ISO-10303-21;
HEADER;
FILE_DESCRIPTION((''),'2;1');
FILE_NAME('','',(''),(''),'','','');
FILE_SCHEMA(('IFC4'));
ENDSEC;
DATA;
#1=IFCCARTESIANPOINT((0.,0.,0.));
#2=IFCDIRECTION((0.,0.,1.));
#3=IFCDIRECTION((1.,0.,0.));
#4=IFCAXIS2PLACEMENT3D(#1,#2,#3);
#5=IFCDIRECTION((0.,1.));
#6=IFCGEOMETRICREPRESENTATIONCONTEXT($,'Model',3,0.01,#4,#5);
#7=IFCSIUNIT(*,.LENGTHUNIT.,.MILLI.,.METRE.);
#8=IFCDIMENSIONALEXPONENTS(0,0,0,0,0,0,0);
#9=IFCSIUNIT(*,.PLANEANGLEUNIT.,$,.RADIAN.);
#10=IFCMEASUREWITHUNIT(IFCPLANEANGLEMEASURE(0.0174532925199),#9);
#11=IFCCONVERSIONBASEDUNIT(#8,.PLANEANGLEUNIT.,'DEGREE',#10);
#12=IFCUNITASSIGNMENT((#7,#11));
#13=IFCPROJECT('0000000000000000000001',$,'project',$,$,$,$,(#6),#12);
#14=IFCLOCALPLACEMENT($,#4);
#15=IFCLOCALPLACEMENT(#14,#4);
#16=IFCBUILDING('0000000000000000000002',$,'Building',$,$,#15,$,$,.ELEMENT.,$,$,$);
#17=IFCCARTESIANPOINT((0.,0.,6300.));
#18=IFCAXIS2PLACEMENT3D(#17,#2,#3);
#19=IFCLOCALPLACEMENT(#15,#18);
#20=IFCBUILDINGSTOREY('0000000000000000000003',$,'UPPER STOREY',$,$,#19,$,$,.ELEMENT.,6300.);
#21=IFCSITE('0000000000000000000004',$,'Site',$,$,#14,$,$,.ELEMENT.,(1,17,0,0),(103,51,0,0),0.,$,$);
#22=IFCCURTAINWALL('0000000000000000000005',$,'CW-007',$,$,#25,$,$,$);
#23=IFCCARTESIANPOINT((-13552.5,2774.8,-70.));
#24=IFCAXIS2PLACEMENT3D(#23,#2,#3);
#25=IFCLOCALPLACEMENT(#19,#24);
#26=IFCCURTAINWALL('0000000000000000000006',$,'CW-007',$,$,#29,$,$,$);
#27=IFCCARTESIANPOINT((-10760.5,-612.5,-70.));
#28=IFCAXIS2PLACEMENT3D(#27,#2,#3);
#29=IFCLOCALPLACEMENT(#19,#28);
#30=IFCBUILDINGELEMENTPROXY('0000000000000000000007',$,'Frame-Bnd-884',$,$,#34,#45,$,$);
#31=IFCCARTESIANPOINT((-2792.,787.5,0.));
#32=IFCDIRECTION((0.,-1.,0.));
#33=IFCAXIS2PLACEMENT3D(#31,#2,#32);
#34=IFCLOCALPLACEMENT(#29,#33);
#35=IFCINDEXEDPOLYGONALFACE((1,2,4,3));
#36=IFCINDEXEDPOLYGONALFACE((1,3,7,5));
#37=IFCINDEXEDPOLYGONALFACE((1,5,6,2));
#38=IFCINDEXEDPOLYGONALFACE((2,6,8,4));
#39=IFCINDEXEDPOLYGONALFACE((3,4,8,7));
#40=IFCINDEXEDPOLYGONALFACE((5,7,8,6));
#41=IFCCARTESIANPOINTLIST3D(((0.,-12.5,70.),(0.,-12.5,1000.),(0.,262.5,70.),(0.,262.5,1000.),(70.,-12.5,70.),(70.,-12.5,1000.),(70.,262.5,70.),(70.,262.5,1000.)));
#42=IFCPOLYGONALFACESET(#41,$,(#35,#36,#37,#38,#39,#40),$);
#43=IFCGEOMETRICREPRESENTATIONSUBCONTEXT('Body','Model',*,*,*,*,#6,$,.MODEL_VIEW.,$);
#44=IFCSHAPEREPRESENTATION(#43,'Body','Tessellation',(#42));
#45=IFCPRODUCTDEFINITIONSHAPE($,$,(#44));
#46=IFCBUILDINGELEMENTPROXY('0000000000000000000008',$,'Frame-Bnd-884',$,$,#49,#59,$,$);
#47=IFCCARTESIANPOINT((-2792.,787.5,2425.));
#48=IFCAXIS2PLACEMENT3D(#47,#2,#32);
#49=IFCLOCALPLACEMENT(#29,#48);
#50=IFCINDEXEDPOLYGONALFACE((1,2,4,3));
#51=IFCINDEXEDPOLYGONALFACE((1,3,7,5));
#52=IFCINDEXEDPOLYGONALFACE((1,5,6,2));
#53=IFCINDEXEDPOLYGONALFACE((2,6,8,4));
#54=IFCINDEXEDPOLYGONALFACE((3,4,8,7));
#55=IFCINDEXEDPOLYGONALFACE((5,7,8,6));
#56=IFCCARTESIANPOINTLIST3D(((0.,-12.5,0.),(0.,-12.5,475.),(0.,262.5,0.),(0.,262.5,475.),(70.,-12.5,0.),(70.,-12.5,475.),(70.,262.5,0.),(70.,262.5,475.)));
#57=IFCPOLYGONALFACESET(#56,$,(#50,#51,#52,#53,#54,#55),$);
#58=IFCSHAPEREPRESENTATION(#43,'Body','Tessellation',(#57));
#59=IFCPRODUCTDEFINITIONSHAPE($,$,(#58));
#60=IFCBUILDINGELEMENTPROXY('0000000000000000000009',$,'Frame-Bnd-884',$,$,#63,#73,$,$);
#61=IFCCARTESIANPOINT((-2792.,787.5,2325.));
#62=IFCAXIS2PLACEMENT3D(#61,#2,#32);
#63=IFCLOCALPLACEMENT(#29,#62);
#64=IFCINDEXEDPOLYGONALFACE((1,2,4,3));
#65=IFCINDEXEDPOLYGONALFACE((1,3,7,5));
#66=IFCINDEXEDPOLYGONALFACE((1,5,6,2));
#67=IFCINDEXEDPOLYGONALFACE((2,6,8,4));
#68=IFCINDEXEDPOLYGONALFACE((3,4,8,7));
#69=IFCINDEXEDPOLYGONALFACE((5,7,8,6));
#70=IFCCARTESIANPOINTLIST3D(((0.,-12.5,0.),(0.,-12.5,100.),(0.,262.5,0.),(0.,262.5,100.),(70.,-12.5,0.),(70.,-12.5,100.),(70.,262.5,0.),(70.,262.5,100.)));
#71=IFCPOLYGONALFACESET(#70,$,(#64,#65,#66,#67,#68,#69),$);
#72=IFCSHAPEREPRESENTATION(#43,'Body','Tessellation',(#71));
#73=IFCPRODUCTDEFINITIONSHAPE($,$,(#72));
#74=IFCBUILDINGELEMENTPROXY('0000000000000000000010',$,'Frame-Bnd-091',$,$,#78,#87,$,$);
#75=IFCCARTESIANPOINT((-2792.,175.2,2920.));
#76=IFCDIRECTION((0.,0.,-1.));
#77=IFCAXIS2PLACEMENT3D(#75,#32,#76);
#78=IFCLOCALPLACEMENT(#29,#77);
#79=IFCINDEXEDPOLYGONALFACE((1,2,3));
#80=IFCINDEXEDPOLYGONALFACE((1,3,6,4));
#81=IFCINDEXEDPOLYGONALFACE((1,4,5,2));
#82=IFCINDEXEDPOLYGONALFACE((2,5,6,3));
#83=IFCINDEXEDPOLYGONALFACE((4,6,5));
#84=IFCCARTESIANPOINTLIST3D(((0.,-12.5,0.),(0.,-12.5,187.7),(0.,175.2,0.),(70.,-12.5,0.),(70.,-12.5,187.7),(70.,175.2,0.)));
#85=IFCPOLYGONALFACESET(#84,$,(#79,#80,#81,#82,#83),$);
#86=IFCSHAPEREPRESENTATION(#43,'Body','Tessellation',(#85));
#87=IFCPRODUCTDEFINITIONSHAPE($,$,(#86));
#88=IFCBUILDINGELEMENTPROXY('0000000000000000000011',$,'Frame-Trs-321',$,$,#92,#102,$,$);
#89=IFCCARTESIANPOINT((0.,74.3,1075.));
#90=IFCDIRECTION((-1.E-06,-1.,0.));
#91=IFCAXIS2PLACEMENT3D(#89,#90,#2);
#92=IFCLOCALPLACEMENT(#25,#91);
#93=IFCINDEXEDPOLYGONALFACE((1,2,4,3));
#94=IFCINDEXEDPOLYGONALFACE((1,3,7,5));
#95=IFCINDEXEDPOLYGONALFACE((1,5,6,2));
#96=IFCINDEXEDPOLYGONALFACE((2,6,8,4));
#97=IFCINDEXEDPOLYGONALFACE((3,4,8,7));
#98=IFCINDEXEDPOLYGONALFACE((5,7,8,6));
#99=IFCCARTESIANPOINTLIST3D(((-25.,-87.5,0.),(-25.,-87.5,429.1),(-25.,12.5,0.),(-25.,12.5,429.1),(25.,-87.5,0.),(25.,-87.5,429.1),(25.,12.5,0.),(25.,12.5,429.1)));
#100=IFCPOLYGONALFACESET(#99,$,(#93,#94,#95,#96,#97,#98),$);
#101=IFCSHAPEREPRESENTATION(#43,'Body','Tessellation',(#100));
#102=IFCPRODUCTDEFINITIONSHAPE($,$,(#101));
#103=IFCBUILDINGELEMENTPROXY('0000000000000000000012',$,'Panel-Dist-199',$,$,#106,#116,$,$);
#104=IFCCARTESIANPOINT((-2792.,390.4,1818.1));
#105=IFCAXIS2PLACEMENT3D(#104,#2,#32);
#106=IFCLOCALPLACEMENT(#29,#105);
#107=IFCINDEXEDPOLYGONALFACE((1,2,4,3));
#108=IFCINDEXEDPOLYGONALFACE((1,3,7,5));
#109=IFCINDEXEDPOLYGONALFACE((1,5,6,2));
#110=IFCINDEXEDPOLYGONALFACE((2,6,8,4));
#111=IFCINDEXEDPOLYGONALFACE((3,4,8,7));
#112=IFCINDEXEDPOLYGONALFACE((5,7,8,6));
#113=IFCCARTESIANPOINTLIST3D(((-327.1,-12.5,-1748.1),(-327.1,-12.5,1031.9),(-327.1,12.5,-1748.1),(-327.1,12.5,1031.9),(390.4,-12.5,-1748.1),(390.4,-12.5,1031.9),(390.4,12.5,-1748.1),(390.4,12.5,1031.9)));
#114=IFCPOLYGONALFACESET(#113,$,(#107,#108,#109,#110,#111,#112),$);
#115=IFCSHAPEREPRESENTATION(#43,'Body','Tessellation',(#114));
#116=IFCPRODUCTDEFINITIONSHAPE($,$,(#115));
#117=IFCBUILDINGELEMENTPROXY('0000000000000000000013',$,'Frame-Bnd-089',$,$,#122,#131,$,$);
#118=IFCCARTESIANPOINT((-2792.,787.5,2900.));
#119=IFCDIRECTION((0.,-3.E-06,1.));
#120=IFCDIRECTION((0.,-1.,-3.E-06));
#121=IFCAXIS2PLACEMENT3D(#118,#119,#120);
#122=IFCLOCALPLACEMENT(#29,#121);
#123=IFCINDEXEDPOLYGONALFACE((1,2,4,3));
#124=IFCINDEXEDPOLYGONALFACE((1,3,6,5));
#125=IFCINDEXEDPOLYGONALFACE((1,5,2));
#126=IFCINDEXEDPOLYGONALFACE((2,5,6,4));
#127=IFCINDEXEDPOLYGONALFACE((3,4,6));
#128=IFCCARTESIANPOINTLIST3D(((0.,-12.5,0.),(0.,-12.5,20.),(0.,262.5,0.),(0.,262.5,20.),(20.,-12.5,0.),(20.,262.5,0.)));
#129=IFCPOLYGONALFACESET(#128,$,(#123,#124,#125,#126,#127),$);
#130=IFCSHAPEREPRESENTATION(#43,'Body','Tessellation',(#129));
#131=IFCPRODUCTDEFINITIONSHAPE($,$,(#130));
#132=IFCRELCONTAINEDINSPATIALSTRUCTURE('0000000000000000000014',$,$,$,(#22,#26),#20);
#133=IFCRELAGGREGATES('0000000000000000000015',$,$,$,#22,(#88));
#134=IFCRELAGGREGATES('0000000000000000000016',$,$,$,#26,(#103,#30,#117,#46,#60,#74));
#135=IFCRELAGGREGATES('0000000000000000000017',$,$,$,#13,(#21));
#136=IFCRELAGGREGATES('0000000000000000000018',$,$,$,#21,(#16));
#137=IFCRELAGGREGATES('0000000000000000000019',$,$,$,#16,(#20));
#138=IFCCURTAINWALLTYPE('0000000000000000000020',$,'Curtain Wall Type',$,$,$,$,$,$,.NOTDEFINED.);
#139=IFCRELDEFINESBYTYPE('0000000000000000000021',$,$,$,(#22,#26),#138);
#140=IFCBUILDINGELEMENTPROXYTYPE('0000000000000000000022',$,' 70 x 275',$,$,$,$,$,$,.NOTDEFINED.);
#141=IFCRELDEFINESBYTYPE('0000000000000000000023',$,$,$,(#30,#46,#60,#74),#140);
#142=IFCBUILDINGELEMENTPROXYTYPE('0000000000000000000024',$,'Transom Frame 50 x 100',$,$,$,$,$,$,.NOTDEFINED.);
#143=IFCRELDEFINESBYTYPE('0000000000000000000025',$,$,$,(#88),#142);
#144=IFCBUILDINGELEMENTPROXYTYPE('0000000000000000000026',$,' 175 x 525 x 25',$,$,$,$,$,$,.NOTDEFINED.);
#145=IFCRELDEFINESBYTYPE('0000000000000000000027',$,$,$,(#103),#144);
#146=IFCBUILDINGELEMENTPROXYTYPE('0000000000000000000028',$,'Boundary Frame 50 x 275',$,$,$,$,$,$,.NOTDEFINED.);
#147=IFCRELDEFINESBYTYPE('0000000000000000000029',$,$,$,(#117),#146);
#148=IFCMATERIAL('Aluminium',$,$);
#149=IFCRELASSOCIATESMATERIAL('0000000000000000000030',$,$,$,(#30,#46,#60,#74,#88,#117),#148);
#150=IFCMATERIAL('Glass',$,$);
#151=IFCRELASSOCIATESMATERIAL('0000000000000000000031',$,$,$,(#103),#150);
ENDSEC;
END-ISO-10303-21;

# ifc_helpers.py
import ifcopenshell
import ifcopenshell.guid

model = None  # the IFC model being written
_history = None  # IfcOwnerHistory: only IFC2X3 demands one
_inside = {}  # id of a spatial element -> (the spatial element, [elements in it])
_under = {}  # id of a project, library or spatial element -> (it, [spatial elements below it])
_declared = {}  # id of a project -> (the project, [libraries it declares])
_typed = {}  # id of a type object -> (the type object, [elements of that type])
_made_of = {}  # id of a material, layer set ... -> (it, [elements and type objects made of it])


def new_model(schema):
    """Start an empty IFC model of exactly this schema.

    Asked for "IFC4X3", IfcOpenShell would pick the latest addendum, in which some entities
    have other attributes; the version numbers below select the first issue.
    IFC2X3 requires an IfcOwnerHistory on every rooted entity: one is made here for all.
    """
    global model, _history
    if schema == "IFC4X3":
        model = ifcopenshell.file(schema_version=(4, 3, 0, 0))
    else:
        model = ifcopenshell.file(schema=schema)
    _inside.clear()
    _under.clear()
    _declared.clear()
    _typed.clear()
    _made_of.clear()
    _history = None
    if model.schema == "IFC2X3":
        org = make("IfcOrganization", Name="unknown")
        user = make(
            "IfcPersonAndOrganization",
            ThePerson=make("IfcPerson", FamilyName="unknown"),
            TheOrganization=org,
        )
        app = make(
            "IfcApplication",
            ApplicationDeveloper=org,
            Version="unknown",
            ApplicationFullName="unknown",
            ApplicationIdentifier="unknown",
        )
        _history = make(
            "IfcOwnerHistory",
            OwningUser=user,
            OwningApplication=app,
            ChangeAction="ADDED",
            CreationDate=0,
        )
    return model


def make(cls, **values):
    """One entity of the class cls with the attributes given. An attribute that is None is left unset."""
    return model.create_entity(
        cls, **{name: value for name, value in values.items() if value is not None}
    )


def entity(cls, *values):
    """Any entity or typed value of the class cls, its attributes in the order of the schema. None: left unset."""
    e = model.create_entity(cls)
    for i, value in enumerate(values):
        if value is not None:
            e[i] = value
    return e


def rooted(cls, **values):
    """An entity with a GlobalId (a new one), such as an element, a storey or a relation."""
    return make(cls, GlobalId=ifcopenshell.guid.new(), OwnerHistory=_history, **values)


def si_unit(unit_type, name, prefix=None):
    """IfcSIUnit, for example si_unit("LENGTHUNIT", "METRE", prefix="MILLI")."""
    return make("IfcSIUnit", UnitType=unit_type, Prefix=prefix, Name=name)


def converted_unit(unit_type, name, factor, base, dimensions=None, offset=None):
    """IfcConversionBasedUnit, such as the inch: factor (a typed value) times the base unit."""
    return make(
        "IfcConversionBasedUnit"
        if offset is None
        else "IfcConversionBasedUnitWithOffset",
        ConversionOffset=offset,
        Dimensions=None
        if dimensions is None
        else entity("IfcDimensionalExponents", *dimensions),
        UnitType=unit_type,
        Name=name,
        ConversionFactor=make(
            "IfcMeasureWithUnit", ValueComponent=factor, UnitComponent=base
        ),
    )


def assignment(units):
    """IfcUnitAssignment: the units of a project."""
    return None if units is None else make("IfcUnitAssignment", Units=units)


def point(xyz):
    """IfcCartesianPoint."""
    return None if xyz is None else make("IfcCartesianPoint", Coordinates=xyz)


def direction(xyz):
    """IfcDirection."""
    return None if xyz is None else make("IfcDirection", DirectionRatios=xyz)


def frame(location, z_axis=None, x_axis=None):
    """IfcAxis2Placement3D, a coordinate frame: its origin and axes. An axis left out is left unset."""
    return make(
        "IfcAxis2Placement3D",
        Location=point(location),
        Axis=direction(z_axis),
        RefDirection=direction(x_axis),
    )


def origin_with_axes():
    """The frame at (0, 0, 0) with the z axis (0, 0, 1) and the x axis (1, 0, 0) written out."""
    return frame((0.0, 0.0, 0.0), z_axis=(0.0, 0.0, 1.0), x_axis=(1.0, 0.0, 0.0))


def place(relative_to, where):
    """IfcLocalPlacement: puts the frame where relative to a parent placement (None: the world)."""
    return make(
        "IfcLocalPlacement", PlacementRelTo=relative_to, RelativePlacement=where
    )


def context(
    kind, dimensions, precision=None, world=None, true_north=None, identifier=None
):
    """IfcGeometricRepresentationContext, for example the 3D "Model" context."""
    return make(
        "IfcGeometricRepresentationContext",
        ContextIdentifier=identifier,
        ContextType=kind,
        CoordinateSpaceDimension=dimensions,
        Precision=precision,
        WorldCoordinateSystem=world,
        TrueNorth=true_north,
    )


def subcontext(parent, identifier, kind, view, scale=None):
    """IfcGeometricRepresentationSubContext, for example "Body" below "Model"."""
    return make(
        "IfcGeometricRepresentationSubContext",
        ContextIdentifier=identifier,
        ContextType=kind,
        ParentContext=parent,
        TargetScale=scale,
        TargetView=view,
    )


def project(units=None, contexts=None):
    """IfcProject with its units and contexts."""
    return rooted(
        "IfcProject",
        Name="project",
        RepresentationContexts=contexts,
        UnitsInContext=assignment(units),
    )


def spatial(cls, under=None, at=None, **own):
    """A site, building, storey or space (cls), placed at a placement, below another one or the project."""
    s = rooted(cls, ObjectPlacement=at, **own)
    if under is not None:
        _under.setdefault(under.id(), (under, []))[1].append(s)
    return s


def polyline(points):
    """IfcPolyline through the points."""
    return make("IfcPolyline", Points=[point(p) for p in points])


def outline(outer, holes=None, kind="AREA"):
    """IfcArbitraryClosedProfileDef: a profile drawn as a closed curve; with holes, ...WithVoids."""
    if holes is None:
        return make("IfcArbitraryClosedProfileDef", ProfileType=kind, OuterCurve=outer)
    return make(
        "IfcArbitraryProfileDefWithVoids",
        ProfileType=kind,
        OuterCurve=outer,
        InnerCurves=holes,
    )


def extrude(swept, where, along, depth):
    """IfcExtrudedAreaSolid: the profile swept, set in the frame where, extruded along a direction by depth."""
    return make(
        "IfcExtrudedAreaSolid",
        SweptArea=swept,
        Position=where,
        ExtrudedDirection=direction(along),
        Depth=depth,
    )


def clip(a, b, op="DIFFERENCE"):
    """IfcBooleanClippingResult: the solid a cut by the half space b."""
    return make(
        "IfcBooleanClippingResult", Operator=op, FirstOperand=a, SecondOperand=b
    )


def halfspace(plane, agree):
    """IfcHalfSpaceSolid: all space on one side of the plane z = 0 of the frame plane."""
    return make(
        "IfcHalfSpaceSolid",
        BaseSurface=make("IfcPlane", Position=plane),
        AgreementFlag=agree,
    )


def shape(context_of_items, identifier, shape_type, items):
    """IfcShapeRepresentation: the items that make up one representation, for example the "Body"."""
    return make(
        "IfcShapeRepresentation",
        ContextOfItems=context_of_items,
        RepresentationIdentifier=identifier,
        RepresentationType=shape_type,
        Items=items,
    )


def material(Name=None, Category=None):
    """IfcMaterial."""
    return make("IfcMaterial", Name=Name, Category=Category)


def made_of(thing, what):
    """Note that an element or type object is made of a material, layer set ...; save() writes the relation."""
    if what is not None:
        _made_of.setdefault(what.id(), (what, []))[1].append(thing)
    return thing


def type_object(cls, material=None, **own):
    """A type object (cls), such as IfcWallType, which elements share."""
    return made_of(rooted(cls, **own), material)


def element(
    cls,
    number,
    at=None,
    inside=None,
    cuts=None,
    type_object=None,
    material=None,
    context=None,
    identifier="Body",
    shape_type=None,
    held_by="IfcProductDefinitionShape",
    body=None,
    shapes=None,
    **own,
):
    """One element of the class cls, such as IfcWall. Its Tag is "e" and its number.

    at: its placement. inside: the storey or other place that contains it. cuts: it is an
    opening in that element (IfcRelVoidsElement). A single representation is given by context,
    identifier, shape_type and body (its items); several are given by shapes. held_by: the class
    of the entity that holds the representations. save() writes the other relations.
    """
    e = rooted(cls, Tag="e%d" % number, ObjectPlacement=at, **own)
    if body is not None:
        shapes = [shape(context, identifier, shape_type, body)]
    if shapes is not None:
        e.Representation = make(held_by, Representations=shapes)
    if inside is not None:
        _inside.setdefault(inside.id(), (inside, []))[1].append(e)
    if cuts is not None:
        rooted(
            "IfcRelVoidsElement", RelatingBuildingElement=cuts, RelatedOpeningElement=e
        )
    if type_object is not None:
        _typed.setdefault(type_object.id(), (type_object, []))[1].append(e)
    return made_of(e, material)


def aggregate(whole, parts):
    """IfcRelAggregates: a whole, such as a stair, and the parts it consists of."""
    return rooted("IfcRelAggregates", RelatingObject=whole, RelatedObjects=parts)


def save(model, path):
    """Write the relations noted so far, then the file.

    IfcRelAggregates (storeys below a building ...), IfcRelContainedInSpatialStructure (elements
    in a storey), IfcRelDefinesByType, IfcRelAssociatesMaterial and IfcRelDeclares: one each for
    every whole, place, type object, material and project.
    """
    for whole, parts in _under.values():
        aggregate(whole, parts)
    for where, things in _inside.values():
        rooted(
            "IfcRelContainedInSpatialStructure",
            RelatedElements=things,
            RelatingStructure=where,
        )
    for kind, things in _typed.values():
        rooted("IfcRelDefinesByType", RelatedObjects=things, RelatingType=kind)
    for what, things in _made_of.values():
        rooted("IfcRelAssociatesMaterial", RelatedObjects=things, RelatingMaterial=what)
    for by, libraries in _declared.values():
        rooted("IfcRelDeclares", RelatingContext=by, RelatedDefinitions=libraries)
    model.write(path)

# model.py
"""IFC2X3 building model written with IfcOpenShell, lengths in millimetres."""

from ifc_helpers import new_model, entity, si_unit, converted_unit, direction, frame, origin_with_axes, place, context, subcontext, project, spatial, polyline, outline, extrude, clip, halfspace, material, type_object, element, aggregate, save


model = new_model("IFC2X3")

# Units and contexts
model_context = context("Model", 3, precision=0.01, world=origin_with_axes(), true_north=direction((0.0, 1.0)))
body_context = subcontext(model_context, "Body", "Model", "MODEL_VIEW")
ifc_project = project(units=[si_unit("LENGTHUNIT", "METRE", prefix="MILLI"), converted_unit("PLANEANGLEUNIT", "DEGREE", entity("IfcPlaneAngleMeasure", 0.0174532925199), si_unit("PLANEANGLEUNIT", "RADIAN"), dimensions=[0, 0, 0, 0, 0, 0, 0])], contexts=[model_context])

# Site, building, storey
site_placement = place(None, origin_with_axes())
site = spatial("IfcSite", under=ifc_project, at=site_placement, Name="Site", CompositionType="ELEMENT", RefLatitude=(1, 17, 0, 0), RefLongitude=(103, 51, 0, 0), RefElevation=0.0)
building_placement = place(site_placement, origin_with_axes())
building = spatial("IfcBuilding", under=site, at=building_placement, Name="Building", CompositionType="ELEMENT")
storey_placement = place(building_placement, frame((0.0, 0.0, 6300.0), z_axis=(0.0, 0.0, 1.0), x_axis=(1.0, 0.0, 0.0)))
storey = spatial("IfcBuildingStorey", under=building, at=storey_placement, Name="UPPER STOREY", CompositionType="ELEMENT", Elevation=6300.0)

# Curtain walls, building element proxies
curtain_wall_type = type_object("IfcCurtainWallType", Name="Curtain Wall Type", PredefinedType="NOTDEFINED")
curtain_wall_1_placement = place(storey_placement, frame((-13552.5, 2774.8, -70.0), z_axis=(0.0, 0.0, 1.0), x_axis=(1.0, 0.0, 0.0)))
curtain_wall_1 = element("IfcCurtainWall", 1, at=curtain_wall_1_placement, inside=storey, type_object=curtain_wall_type, Name="CW-007")
ifc_material_1 = material(Name="Glass")
ifc_material_2 = material(Name="Aluminium")
building_element_proxy_type_1 = type_object("IfcBuildingElementProxyType", Name=" 70 x 275", PredefinedType="NOTDEFINED")
curtain_wall_2_placement = place(storey_placement, frame((-10760.5, -612.5, -70.0), z_axis=(0.0, 0.0, 1.0), x_axis=(1.0, 0.0, 0.0)))
curtain_wall_2 = element("IfcCurtainWall", 2, at=curtain_wall_2_placement, inside=storey, type_object=curtain_wall_type, Name="CW-007")
proxy_1_placement = place(curtain_wall_2_placement, frame((-2792.0, 787.5, 0.0), z_axis=(0.0, 0.0, 1.0), x_axis=(0.0, -1.0, 0.0)))
proxy_1 = element("IfcBuildingElementProxy", 3, at=proxy_1_placement, type_object=building_element_proxy_type_1, material=ifc_material_2, Name="Frame-Bnd-884", context=body_context, shape_type="SweptSolid", body=[
    extrude(outline(polyline([(262.5, -70.0), (262.5, 0.0), (-12.5, 0.0), (-12.5, -70.0), (262.5, -70.0)])), frame((0.0, 0.0, 70.0), z_axis=(0.0, 0.0, 1.0), x_axis=(0.0, 1.0, 0.0)), (0.0, 0.0, 1.0), 930.0),
])
proxy_2_placement = place(curtain_wall_2_placement, frame((-2792.0, 787.5, 2425.0), z_axis=(0.0, 0.0, 1.0), x_axis=(0.0, -1.0, 0.0)))
proxy_2 = element("IfcBuildingElementProxy", 4, at=proxy_2_placement, type_object=building_element_proxy_type_1, material=ifc_material_2, Name="Frame-Bnd-884", context=body_context, shape_type="SweptSolid", body=[
    extrude(outline(polyline([(262.5, -70.0), (262.5, 0.0), (-12.5, 0.0), (-12.5, -70.0), (262.5, -70.0)])), frame((0.0, 0.0, 0.0), z_axis=(0.0, 0.0, 1.0), x_axis=(0.0, 1.0, 0.0)), (0.0, 0.0, 1.0), 475.0),
])
proxy_3_placement = place(curtain_wall_2_placement, frame((-2792.0, 787.5, 2325.0), z_axis=(0.0, 0.0, 1.0), x_axis=(0.0, -1.0, 0.0)))
proxy_3 = element("IfcBuildingElementProxy", 5, at=proxy_3_placement, type_object=building_element_proxy_type_1, material=ifc_material_2, Name="Frame-Bnd-884", context=body_context, shape_type="SweptSolid", body=[
    extrude(outline(polyline([(262.5, -70.0), (262.5, 0.0), (-12.5, 0.0), (-12.5, -70.0), (262.5, -70.0)])), frame((0.0, 0.0, 0.0), z_axis=(0.0, 0.0, 1.0), x_axis=(0.0, 1.0, 0.0)), (0.0, 0.0, 1.0), 100.0),
])
proxy_4_placement = place(curtain_wall_2_placement, frame((-2792.0, 175.2, 2920.0), z_axis=(0.0, -1.0, 0.0), x_axis=(0.0, 0.0, -1.0)))
proxy_4 = element("IfcBuildingElementProxy", 6, at=proxy_4_placement, type_object=building_element_proxy_type_1, material=ifc_material_2, Name="Frame-Bnd-091", context=body_context, shape_type="Clipping", body=[
    clip(extrude(outline(polyline([(-175.2, 70.0), (-175.2, 0.0), (12.5, 0.0), (12.5, 70.0), (-175.2, 70.0)])), frame((0.0, 0.0, 0.0), z_axis=(0.0, 0.0, 1.0), x_axis=(0.0, -1.0, 0.0)), (0.0, 0.0, 1.0), 187.7), halfspace(frame((0.0, 87.6, 87.6), z_axis=(0.0, -0.707107, -0.707107), x_axis=(0.0, 0.707107, -0.707107)), True)),
])

# Building element proxies
building_element_proxy_type_2 = type_object("IfcBuildingElementProxyType", Name="Transom Frame 50 x 100", PredefinedType="NOTDEFINED")
proxy_5_placement = place(curtain_wall_1_placement, frame((0.0, 74.3, 1075.0), z_axis=(-0.000001, -1.0, 0.0), x_axis=(0.0, 0.0, 1.0)))
proxy_5 = element("IfcBuildingElementProxy", 7, at=proxy_5_placement, type_object=building_element_proxy_type_2, material=ifc_material_2, Name="Frame-Trs-321", context=body_context, shape_type="SweptSolid", body=[
    extrude(outline(polyline([(-87.5, -25.0), (12.5, -25.0), (12.5, 25.0), (-87.5, 25.0), (-87.5, -25.0)])), frame((0.0, 0.0, 0.0), z_axis=(0.0, 0.0, 1.0), x_axis=(0.0, 1.0, 0.0)), (0.0, 0.0, 1.0), 429.1),
])
aggregate(curtain_wall_1, [proxy_5])
building_element_proxy_type_3 = type_object("IfcBuildingElementProxyType", Name=" 175 x 525 x 25", PredefinedType="NOTDEFINED")
proxy_6_placement = place(curtain_wall_2_placement, frame((-2792.0, 390.4, 1818.1), z_axis=(0.0, 0.0, 1.0), x_axis=(0.0, -1.0, 0.0)))
proxy_6 = element("IfcBuildingElementProxy", 8, at=proxy_6_placement, type_object=building_element_proxy_type_3, material=ifc_material_1, Name="Panel-Dist-199", context=body_context, shape_type="SweptSolid", body=[
    extrude(outline(polyline([(-327.1, -1031.9), (390.4, -1031.9), (390.4, 1748.1), (-327.1, 1748.1), (-327.1, -1031.9)])), frame((0.0, -12.5, 0.0), z_axis=(0.0, 1.0, 0.0), x_axis=(1.0, 0.0, 0.0)), (0.0, 0.0, 1.0), 25.0),
])
building_element_proxy_type_4 = type_object("IfcBuildingElementProxyType", Name="Boundary Frame 50 x 275", PredefinedType="NOTDEFINED")
proxy_7_placement = place(curtain_wall_2_placement, frame((-2792.0, 787.5, 2900.0), z_axis=(0.0, -0.000003, 1.0), x_axis=(0.0, -1.0, -0.000003)))
proxy_7 = element("IfcBuildingElementProxy", 9, at=proxy_7_placement, type_object=building_element_proxy_type_4, material=ifc_material_2, Name="Frame-Bnd-089", context=body_context, shape_type="Clipping", body=[
    clip(extrude(outline(polyline([(-12.5, -20.0), (262.5, -20.0), (262.5, 0.0), (-12.5, 0.0), (-12.5, -20.0)])), frame((0.0, 0.0, 0.0), z_axis=(0.0, 0.0, 1.0), x_axis=(0.0, 1.0, 0.0)), (0.0, 0.0, 1.0), 20.0), halfspace(frame((10.0, 0.0, 10.0), z_axis=(-0.707104, 0.0, -0.70711), x_axis=(0.0, 1.0, 0.0)), True)),
])
aggregate(curtain_wall_2, [proxy_6, proxy_1, proxy_7, proxy_2, proxy_3, proxy_4])

save(model, "model.ifc")
